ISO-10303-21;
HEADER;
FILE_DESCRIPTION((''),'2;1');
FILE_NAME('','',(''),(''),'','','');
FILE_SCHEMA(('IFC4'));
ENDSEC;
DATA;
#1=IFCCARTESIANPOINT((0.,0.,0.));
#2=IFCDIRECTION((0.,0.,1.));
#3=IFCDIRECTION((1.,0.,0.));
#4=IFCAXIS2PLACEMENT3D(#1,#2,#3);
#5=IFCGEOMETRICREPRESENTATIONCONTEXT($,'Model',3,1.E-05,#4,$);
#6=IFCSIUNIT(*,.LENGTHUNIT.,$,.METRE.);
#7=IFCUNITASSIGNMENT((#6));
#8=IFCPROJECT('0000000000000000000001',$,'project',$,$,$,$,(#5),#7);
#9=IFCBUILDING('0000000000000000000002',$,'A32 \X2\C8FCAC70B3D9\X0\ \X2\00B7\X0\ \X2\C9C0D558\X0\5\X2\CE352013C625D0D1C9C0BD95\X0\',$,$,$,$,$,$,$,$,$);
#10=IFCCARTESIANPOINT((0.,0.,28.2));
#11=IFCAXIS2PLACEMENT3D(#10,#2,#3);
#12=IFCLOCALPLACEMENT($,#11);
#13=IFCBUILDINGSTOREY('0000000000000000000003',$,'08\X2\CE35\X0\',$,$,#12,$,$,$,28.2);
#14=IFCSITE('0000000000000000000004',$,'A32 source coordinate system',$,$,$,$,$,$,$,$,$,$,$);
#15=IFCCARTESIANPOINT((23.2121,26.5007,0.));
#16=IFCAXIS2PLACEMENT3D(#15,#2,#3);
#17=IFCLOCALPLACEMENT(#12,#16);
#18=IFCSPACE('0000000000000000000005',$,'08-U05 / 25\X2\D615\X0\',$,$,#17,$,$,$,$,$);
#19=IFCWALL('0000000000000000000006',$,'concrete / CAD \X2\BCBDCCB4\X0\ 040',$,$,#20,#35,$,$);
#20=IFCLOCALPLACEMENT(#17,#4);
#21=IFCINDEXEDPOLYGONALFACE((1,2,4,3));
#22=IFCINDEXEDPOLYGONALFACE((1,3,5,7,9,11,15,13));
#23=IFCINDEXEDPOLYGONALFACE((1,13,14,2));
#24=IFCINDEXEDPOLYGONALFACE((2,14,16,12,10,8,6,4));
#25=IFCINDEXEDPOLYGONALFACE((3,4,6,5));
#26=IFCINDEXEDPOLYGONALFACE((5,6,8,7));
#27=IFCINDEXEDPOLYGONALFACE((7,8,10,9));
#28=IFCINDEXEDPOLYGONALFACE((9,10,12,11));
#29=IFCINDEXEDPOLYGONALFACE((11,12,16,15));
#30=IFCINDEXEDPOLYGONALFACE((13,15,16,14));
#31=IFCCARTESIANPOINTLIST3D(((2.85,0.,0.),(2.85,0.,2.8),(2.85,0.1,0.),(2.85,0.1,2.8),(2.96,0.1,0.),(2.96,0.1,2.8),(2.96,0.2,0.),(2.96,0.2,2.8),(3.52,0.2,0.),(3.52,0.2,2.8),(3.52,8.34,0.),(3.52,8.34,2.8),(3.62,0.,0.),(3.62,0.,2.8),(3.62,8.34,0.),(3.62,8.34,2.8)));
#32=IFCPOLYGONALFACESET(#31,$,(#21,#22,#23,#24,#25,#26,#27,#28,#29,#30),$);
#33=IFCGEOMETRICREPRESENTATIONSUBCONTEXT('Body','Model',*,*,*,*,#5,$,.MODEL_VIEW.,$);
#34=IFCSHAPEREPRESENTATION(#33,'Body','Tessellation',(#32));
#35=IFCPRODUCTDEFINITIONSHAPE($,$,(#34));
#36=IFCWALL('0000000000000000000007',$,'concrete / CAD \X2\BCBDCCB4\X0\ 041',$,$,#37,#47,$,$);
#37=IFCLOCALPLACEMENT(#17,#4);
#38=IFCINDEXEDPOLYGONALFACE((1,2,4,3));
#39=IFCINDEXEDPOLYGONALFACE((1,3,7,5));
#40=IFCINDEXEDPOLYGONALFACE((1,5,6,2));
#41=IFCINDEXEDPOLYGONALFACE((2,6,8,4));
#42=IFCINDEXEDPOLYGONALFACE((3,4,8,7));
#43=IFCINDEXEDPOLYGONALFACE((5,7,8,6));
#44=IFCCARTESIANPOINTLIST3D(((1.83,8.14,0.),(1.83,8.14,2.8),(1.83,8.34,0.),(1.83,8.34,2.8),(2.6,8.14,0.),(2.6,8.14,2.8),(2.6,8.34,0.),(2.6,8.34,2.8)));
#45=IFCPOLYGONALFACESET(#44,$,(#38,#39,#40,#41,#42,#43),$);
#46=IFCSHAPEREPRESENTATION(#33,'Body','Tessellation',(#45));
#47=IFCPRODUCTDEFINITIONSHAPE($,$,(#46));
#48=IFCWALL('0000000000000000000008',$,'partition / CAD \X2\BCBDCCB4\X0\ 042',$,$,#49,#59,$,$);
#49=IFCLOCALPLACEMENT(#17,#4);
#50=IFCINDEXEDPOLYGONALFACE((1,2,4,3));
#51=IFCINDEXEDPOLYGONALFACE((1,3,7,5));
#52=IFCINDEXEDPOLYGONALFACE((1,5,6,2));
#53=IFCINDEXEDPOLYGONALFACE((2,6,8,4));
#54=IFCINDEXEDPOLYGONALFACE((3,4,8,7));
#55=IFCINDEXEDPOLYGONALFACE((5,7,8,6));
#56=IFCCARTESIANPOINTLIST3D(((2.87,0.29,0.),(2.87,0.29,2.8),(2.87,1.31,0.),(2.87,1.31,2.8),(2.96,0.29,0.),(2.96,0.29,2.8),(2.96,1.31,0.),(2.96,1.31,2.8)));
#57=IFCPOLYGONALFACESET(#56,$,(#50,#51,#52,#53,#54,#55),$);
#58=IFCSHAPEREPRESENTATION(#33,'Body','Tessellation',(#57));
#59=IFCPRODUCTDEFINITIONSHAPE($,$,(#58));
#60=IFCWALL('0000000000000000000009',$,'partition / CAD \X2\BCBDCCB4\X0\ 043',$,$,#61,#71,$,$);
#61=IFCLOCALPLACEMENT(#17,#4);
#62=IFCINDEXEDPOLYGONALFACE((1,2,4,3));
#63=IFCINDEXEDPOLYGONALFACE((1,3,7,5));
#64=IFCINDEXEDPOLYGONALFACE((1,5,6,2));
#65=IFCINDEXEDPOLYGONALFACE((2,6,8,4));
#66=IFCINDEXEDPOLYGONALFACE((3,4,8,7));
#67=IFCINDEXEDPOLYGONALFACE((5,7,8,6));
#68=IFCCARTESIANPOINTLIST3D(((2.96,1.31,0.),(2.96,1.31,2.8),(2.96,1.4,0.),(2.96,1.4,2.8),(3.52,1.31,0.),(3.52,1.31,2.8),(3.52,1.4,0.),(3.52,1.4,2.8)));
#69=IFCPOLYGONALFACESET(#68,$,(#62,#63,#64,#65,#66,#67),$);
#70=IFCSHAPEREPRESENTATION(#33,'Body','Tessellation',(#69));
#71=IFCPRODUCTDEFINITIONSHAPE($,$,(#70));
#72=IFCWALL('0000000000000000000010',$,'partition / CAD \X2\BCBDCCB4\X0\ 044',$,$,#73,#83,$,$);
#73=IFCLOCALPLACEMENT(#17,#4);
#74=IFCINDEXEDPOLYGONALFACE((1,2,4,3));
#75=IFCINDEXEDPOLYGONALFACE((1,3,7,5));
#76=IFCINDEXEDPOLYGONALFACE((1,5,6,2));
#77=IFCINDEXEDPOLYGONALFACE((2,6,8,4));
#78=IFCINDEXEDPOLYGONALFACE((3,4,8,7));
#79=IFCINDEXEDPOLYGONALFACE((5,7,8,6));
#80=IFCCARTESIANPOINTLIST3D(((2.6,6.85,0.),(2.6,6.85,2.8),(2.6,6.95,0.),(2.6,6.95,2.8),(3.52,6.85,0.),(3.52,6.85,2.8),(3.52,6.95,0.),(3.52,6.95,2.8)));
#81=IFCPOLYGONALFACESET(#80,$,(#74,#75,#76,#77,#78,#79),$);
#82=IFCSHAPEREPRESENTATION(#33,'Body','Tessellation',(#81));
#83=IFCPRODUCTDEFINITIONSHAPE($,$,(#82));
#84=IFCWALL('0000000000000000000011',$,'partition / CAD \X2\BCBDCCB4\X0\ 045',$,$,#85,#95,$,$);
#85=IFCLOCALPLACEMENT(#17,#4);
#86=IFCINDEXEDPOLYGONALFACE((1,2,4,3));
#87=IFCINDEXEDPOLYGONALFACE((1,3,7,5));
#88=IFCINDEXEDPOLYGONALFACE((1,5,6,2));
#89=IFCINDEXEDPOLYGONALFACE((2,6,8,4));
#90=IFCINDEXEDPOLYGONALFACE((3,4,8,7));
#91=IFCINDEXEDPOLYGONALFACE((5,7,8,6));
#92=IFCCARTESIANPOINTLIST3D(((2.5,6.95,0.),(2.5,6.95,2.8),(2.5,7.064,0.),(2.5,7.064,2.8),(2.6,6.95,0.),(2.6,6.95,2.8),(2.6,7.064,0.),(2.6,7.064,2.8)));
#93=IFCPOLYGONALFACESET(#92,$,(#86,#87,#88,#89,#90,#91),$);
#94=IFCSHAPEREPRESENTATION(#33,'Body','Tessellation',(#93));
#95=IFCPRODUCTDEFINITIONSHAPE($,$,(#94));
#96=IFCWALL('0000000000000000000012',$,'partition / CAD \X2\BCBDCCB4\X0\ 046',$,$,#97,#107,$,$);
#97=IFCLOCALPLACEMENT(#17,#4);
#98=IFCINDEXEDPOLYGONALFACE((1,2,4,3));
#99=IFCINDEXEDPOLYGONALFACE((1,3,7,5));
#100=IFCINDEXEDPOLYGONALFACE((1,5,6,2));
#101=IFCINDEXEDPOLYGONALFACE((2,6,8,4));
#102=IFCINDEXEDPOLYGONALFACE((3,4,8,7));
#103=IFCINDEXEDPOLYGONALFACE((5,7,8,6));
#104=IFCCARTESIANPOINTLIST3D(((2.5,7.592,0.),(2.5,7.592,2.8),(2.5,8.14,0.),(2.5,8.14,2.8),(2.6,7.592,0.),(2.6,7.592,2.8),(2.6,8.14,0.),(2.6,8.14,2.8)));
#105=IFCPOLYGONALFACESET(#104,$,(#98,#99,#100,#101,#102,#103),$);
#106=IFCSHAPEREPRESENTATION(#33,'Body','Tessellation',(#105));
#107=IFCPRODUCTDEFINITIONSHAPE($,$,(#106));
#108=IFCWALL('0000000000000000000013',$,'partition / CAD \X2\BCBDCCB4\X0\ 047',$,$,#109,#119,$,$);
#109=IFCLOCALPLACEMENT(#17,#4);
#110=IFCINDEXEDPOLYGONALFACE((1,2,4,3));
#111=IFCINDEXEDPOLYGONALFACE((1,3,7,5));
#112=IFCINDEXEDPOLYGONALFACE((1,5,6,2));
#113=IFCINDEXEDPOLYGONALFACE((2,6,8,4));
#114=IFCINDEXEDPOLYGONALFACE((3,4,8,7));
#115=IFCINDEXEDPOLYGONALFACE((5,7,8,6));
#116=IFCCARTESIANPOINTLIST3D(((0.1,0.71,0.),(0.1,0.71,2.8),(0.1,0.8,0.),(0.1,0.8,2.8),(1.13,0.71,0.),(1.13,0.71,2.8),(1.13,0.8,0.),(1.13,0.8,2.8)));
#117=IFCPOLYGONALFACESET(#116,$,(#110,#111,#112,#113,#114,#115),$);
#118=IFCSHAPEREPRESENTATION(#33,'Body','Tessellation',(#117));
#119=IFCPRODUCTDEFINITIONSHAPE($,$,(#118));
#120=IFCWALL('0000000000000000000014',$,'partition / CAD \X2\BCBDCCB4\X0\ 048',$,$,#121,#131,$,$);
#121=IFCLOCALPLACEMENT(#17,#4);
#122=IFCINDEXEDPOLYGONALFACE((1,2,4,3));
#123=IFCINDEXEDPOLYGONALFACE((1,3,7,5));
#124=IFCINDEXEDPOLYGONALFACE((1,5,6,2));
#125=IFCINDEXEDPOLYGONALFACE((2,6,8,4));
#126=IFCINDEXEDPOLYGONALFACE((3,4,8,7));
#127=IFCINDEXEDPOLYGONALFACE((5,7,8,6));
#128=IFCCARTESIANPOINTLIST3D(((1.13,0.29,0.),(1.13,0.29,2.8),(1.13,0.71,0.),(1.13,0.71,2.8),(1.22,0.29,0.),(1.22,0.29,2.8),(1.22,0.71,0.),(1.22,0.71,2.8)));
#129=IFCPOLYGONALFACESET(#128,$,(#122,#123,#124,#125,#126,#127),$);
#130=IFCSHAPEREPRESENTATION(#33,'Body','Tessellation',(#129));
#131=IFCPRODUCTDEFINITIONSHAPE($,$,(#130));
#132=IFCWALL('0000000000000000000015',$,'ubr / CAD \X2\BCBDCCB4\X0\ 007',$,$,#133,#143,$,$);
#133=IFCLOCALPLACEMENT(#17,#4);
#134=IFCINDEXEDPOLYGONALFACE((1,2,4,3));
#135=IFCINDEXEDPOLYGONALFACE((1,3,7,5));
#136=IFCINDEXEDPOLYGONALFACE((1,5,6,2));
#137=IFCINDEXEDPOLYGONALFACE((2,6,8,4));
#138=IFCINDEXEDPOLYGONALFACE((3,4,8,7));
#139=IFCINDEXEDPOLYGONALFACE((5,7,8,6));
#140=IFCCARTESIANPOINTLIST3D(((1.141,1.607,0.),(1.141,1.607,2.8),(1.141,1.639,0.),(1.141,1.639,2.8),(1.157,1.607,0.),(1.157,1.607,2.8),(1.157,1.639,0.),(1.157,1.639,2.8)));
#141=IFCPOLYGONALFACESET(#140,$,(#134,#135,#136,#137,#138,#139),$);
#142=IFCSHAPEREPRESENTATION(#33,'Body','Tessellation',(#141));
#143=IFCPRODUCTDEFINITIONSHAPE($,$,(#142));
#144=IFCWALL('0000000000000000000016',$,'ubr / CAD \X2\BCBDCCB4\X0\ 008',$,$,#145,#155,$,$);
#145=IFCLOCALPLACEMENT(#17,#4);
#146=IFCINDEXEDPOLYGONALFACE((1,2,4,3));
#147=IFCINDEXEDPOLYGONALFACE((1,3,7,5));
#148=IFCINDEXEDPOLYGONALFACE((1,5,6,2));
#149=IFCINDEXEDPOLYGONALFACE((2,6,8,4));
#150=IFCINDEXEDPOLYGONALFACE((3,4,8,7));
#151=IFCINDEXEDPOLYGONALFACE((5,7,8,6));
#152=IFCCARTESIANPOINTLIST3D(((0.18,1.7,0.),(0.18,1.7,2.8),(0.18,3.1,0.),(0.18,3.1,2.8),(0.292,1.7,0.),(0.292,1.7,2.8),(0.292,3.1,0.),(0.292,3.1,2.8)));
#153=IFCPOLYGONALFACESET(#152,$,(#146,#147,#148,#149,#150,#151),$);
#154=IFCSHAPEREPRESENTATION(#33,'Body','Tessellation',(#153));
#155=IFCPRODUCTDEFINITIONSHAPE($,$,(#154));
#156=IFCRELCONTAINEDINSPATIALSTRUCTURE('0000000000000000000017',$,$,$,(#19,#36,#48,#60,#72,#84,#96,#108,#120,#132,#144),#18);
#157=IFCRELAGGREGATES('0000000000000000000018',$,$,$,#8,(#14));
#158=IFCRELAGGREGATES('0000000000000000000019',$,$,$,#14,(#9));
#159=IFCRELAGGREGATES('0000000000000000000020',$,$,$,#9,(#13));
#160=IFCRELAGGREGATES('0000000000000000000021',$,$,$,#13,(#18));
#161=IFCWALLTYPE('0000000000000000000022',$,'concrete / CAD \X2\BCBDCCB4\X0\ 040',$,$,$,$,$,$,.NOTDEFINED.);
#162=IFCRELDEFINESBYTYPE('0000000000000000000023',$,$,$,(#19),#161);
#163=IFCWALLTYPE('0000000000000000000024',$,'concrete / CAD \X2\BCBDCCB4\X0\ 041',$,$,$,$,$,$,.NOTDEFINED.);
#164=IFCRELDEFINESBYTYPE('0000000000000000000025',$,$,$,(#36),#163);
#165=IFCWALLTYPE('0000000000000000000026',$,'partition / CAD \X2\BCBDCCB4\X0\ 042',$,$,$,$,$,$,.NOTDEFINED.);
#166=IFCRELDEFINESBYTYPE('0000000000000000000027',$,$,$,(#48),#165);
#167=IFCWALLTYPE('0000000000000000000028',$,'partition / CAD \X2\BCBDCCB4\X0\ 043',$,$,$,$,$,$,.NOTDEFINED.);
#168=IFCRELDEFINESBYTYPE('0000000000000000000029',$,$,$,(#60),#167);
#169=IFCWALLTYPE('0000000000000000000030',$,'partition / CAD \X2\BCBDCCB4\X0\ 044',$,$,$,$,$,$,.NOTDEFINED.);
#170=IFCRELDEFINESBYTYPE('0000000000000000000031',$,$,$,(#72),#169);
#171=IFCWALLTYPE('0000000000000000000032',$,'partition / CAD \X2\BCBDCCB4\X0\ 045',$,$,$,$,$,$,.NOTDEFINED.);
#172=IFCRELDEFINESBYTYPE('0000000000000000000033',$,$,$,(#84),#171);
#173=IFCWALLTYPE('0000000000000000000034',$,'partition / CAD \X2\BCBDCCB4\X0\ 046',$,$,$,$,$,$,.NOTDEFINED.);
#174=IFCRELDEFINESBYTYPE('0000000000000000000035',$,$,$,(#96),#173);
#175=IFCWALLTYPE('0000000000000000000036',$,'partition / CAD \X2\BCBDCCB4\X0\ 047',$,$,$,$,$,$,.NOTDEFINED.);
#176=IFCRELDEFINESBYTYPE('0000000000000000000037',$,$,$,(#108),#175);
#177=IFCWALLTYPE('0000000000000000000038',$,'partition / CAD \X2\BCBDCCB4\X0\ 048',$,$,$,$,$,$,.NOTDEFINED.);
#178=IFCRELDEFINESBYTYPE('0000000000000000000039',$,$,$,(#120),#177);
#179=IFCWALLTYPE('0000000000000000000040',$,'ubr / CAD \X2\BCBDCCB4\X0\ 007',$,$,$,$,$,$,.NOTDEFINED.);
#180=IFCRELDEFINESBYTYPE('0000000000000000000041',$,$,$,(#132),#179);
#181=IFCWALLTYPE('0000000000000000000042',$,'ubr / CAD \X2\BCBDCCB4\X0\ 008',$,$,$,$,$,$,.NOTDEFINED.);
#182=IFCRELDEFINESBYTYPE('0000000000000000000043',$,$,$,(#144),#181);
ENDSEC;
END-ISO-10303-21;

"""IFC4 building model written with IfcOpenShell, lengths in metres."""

from ifc_helpers import new_model, si_unit, frame, origin, origin_with_axes, place, context, subcontext, project, spatial, polyline, outline, extrude, source, transform, mapped, type_object, type_shapes, element, save


model = new_model("IFC4")

# Units and contexts
model_context = context("Model", 3, precision=1e-05, world=origin_with_axes())
body_context = subcontext(model_context, "Body", "Model", "MODEL_VIEW")
ifc_project = project(units=[si_unit("LENGTHUNIT", "METRE")], contexts=[model_context])

# Site, building, storey, space
site = spatial("IfcSite", under=ifc_project, Name="A32 source coordinate system")
building = spatial("IfcBuilding", under=site, Name="A32 주거동 · 지하5층–옥탑지붕")
storey_placement = place(None, frame((0.0, 0.0, 28.2), z_axis=(0.0, 0.0, 1.0), x_axis=(1.0, 0.0, 0.0)))
storey = spatial("IfcBuildingStorey", under=building, at=storey_placement, Name="08층", Elevation=28.2)
space_1_placement = place(storey_placement, frame((23.2121, 26.5007, 0.0), z_axis=(0.0, 0.0, 1.0), x_axis=(1.0, 0.0, 0.0)))
space_1 = spatial("IfcSpace", under=storey, at=space_1_placement, Name="08-U05 / 25형")

# Walls
wall_type_1 = type_object("IfcWallType", Name="concrete / CAD 벽체 040", PredefinedType="NOTDEFINED")
shared_shape_1 = source(origin(), body_context, "Body", "SweptSolid", [
    extrude(outline(polyline([(3.62, 8.34), (3.62, 0.0), (2.85, 0.0), (2.85, 0.1), (2.96, 0.1), (2.96, 0.2), (3.52, 0.2), (3.52, 8.34), (3.62, 8.34)])), origin(), (0.0, 0.0, 1.0), 2.8),
])
type_shapes(wall_type_1, [shared_shape_1])
wall_1_placement = place(space_1_placement, origin_with_axes())
element("IfcWall", 1, at=wall_1_placement, inside=space_1, type_object=wall_type_1, Name="concrete / CAD 벽체 040", context=body_context, shape_type="MappedRepresentation", body=[
    mapped(shared_shape_1, transform((0.0, 0.0, 0.0), scale=1.0)),
])
wall_type_2 = type_object("IfcWallType", Name="concrete / CAD 벽체 041", PredefinedType="NOTDEFINED")
shared_shape_2 = source(origin(), body_context, "Body", "SweptSolid", [
    extrude(outline(polyline([(2.6, 8.14), (1.83, 8.14), (1.83, 8.34), (2.6, 8.34), (2.6, 8.14)])), origin(), (0.0, 0.0, 1.0), 2.8),
])
type_shapes(wall_type_2, [shared_shape_2])
wall_2_placement = place(space_1_placement, origin_with_axes())
element("IfcWall", 2, at=wall_2_placement, inside=space_1, type_object=wall_type_2, Name="concrete / CAD 벽체 041", context=body_context, shape_type="MappedRepresentation", body=[
    mapped(shared_shape_2, transform((0.0, 0.0, 0.0), scale=1.0)),
])
wall_type_3 = type_object("IfcWallType", Name="partition / CAD 벽체 042", PredefinedType="NOTDEFINED")
shared_shape_3 = source(origin(), body_context, "Body", "SweptSolid", [
    extrude(outline(polyline([(2.87, 1.31), (2.96, 1.31), (2.96, 0.29), (2.87, 0.29), (2.87, 1.31)])), origin(), (0.0, 0.0, 1.0), 2.8),
])
type_shapes(wall_type_3, [shared_shape_3])
wall_3_placement = place(space_1_placement, origin_with_axes())
element("IfcWall", 3, at=wall_3_placement, inside=space_1, type_object=wall_type_3, Name="partition / CAD 벽체 042", context=body_context, shape_type="MappedRepresentation", body=[
    mapped(shared_shape_3, transform((0.0, 0.0, 0.0), scale=1.0)),
])
wall_type_4 = type_object("IfcWallType", Name="partition / CAD 벽체 043", PredefinedType="NOTDEFINED")
shared_shape_4 = source(origin(), body_context, "Body", "SweptSolid", [
    extrude(outline(polyline([(3.52, 1.4), (3.52, 1.31), (2.96, 1.31), (2.96, 1.4), (3.52, 1.4)])), origin(), (0.0, 0.0, 1.0), 2.8),
])
type_shapes(wall_type_4, [shared_shape_4])
wall_4_placement = place(space_1_placement, origin_with_axes())
element("IfcWall", 4, at=wall_4_placement, inside=space_1, type_object=wall_type_4, Name="partition / CAD 벽체 043", context=body_context, shape_type="MappedRepresentation", body=[
    mapped(shared_shape_4, transform((0.0, 0.0, 0.0), scale=1.0)),
])
wall_type_5 = type_object("IfcWallType", Name="partition / CAD 벽체 044", PredefinedType="NOTDEFINED")
shared_shape_5 = source(origin(), body_context, "Body", "SweptSolid", [
    extrude(outline(polyline([(3.52, 6.95), (3.52, 6.85), (2.6, 6.85), (2.6, 6.95), (3.52, 6.95)])), origin(), (0.0, 0.0, 1.0), 2.8),
])
type_shapes(wall_type_5, [shared_shape_5])
wall_5_placement = place(space_1_placement, origin_with_axes())
element("IfcWall", 5, at=wall_5_placement, inside=space_1, type_object=wall_type_5, Name="partition / CAD 벽체 044", context=body_context, shape_type="MappedRepresentation", body=[
    mapped(shared_shape_5, transform((0.0, 0.0, 0.0), scale=1.0)),
])
wall_type_6 = type_object("IfcWallType", Name="partition / CAD 벽체 045", PredefinedType="NOTDEFINED")
shared_shape_6 = source(origin(), body_context, "Body", "SweptSolid", [
    extrude(outline(polyline([(2.5, 7.064), (2.6, 7.064), (2.6, 6.95), (2.5, 6.95), (2.5, 7.064)])), origin(), (0.0, 0.0, 1.0), 2.8),
])
type_shapes(wall_type_6, [shared_shape_6])
wall_6_placement = place(space_1_placement, origin_with_axes())
element("IfcWall", 6, at=wall_6_placement, inside=space_1, type_object=wall_type_6, Name="partition / CAD 벽체 045", context=body_context, shape_type="MappedRepresentation", body=[
    mapped(shared_shape_6, transform((0.0, 0.0, 0.0), scale=1.0)),
])
wall_type_7 = type_object("IfcWallType", Name="partition / CAD 벽체 046", PredefinedType="NOTDEFINED")
shared_shape_7 = source(origin(), body_context, "Body", "SweptSolid", [
    extrude(outline(polyline([(2.6, 7.592), (2.5, 7.592), (2.5, 8.14), (2.6, 8.14), (2.6, 7.592)])), origin(), (0.0, 0.0, 1.0), 2.8),
])
type_shapes(wall_type_7, [shared_shape_7])
wall_7_placement = place(space_1_placement, origin_with_axes())
element("IfcWall", 7, at=wall_7_placement, inside=space_1, type_object=wall_type_7, Name="partition / CAD 벽체 046", context=body_context, shape_type="MappedRepresentation", body=[
    mapped(shared_shape_7, transform((0.0, 0.0, 0.0), scale=1.0)),
])
wall_type_8 = type_object("IfcWallType", Name="partition / CAD 벽체 047", PredefinedType="NOTDEFINED")
shared_shape_8 = source(origin(), body_context, "Body", "SweptSolid", [
    extrude(outline(polyline([(1.13, 0.71), (0.1, 0.71), (0.1, 0.8), (1.13, 0.8), (1.13, 0.71)])), origin(), (0.0, 0.0, 1.0), 2.8),
])
type_shapes(wall_type_8, [shared_shape_8])
wall_8_placement = place(space_1_placement, origin_with_axes())
element("IfcWall", 8, at=wall_8_placement, inside=space_1, type_object=wall_type_8, Name="partition / CAD 벽체 047", context=body_context, shape_type="MappedRepresentation", body=[
    mapped(shared_shape_8, transform((0.0, 0.0, 0.0), scale=1.0)),
])
wall_type_9 = type_object("IfcWallType", Name="partition / CAD 벽체 048", PredefinedType="NOTDEFINED")
shared_shape_9 = source(origin(), body_context, "Body", "SweptSolid", [
    extrude(outline(polyline([(1.22, 0.29), (1.13, 0.29), (1.13, 0.71), (1.22, 0.71), (1.22, 0.29)])), origin(), (0.0, 0.0, 1.0), 2.8),
])
type_shapes(wall_type_9, [shared_shape_9])
wall_9_placement = place(space_1_placement, origin_with_axes())
element("IfcWall", 9, at=wall_9_placement, inside=space_1, type_object=wall_type_9, Name="partition / CAD 벽체 048", context=body_context, shape_type="MappedRepresentation", body=[
    mapped(shared_shape_9, transform((0.0, 0.0, 0.0), scale=1.0)),
])
wall_type_10 = type_object("IfcWallType", Name="ubr / CAD 벽체 007", PredefinedType="NOTDEFINED")
shared_shape_10 = source(origin(), body_context, "Body", "SweptSolid", [
    extrude(outline(polyline([(1.157, 1.607), (1.141, 1.607), (1.141, 1.639), (1.157, 1.639), (1.157, 1.607)])), origin(), (0.0, 0.0, 1.0), 2.8),
])
type_shapes(wall_type_10, [shared_shape_10])
wall_10_placement = place(space_1_placement, origin_with_axes())
element("IfcWall", 10, at=wall_10_placement, inside=space_1, type_object=wall_type_10, Name="ubr / CAD 벽체 007", context=body_context, shape_type="MappedRepresentation", body=[
    mapped(shared_shape_10, transform((0.0, 0.0, 0.0), scale=1.0)),
])
wall_type_11 = type_object("IfcWallType", Name="ubr / CAD 벽체 008", PredefinedType="NOTDEFINED")
shared_shape_11 = source(origin(), body_context, "Body", "SweptSolid", [
    extrude(outline(polyline([(0.292, 1.7), (0.18, 1.7), (0.18, 3.1), (0.292, 3.1), (0.292, 1.7)])), origin(), (0.0, 0.0, 1.0), 2.8),
])
type_shapes(wall_type_11, [shared_shape_11])
wall_11_placement = place(space_1_placement, origin_with_axes())
element("IfcWall", 11, at=wall_11_placement, inside=space_1, type_object=wall_type_11, Name="ubr / CAD 벽체 008", context=body_context, shape_type="MappedRepresentation", body=[
    mapped(shared_shape_11, transform((0.0, 0.0, 0.0), scale=1.0)),
])

save(model, "model.ifc")
